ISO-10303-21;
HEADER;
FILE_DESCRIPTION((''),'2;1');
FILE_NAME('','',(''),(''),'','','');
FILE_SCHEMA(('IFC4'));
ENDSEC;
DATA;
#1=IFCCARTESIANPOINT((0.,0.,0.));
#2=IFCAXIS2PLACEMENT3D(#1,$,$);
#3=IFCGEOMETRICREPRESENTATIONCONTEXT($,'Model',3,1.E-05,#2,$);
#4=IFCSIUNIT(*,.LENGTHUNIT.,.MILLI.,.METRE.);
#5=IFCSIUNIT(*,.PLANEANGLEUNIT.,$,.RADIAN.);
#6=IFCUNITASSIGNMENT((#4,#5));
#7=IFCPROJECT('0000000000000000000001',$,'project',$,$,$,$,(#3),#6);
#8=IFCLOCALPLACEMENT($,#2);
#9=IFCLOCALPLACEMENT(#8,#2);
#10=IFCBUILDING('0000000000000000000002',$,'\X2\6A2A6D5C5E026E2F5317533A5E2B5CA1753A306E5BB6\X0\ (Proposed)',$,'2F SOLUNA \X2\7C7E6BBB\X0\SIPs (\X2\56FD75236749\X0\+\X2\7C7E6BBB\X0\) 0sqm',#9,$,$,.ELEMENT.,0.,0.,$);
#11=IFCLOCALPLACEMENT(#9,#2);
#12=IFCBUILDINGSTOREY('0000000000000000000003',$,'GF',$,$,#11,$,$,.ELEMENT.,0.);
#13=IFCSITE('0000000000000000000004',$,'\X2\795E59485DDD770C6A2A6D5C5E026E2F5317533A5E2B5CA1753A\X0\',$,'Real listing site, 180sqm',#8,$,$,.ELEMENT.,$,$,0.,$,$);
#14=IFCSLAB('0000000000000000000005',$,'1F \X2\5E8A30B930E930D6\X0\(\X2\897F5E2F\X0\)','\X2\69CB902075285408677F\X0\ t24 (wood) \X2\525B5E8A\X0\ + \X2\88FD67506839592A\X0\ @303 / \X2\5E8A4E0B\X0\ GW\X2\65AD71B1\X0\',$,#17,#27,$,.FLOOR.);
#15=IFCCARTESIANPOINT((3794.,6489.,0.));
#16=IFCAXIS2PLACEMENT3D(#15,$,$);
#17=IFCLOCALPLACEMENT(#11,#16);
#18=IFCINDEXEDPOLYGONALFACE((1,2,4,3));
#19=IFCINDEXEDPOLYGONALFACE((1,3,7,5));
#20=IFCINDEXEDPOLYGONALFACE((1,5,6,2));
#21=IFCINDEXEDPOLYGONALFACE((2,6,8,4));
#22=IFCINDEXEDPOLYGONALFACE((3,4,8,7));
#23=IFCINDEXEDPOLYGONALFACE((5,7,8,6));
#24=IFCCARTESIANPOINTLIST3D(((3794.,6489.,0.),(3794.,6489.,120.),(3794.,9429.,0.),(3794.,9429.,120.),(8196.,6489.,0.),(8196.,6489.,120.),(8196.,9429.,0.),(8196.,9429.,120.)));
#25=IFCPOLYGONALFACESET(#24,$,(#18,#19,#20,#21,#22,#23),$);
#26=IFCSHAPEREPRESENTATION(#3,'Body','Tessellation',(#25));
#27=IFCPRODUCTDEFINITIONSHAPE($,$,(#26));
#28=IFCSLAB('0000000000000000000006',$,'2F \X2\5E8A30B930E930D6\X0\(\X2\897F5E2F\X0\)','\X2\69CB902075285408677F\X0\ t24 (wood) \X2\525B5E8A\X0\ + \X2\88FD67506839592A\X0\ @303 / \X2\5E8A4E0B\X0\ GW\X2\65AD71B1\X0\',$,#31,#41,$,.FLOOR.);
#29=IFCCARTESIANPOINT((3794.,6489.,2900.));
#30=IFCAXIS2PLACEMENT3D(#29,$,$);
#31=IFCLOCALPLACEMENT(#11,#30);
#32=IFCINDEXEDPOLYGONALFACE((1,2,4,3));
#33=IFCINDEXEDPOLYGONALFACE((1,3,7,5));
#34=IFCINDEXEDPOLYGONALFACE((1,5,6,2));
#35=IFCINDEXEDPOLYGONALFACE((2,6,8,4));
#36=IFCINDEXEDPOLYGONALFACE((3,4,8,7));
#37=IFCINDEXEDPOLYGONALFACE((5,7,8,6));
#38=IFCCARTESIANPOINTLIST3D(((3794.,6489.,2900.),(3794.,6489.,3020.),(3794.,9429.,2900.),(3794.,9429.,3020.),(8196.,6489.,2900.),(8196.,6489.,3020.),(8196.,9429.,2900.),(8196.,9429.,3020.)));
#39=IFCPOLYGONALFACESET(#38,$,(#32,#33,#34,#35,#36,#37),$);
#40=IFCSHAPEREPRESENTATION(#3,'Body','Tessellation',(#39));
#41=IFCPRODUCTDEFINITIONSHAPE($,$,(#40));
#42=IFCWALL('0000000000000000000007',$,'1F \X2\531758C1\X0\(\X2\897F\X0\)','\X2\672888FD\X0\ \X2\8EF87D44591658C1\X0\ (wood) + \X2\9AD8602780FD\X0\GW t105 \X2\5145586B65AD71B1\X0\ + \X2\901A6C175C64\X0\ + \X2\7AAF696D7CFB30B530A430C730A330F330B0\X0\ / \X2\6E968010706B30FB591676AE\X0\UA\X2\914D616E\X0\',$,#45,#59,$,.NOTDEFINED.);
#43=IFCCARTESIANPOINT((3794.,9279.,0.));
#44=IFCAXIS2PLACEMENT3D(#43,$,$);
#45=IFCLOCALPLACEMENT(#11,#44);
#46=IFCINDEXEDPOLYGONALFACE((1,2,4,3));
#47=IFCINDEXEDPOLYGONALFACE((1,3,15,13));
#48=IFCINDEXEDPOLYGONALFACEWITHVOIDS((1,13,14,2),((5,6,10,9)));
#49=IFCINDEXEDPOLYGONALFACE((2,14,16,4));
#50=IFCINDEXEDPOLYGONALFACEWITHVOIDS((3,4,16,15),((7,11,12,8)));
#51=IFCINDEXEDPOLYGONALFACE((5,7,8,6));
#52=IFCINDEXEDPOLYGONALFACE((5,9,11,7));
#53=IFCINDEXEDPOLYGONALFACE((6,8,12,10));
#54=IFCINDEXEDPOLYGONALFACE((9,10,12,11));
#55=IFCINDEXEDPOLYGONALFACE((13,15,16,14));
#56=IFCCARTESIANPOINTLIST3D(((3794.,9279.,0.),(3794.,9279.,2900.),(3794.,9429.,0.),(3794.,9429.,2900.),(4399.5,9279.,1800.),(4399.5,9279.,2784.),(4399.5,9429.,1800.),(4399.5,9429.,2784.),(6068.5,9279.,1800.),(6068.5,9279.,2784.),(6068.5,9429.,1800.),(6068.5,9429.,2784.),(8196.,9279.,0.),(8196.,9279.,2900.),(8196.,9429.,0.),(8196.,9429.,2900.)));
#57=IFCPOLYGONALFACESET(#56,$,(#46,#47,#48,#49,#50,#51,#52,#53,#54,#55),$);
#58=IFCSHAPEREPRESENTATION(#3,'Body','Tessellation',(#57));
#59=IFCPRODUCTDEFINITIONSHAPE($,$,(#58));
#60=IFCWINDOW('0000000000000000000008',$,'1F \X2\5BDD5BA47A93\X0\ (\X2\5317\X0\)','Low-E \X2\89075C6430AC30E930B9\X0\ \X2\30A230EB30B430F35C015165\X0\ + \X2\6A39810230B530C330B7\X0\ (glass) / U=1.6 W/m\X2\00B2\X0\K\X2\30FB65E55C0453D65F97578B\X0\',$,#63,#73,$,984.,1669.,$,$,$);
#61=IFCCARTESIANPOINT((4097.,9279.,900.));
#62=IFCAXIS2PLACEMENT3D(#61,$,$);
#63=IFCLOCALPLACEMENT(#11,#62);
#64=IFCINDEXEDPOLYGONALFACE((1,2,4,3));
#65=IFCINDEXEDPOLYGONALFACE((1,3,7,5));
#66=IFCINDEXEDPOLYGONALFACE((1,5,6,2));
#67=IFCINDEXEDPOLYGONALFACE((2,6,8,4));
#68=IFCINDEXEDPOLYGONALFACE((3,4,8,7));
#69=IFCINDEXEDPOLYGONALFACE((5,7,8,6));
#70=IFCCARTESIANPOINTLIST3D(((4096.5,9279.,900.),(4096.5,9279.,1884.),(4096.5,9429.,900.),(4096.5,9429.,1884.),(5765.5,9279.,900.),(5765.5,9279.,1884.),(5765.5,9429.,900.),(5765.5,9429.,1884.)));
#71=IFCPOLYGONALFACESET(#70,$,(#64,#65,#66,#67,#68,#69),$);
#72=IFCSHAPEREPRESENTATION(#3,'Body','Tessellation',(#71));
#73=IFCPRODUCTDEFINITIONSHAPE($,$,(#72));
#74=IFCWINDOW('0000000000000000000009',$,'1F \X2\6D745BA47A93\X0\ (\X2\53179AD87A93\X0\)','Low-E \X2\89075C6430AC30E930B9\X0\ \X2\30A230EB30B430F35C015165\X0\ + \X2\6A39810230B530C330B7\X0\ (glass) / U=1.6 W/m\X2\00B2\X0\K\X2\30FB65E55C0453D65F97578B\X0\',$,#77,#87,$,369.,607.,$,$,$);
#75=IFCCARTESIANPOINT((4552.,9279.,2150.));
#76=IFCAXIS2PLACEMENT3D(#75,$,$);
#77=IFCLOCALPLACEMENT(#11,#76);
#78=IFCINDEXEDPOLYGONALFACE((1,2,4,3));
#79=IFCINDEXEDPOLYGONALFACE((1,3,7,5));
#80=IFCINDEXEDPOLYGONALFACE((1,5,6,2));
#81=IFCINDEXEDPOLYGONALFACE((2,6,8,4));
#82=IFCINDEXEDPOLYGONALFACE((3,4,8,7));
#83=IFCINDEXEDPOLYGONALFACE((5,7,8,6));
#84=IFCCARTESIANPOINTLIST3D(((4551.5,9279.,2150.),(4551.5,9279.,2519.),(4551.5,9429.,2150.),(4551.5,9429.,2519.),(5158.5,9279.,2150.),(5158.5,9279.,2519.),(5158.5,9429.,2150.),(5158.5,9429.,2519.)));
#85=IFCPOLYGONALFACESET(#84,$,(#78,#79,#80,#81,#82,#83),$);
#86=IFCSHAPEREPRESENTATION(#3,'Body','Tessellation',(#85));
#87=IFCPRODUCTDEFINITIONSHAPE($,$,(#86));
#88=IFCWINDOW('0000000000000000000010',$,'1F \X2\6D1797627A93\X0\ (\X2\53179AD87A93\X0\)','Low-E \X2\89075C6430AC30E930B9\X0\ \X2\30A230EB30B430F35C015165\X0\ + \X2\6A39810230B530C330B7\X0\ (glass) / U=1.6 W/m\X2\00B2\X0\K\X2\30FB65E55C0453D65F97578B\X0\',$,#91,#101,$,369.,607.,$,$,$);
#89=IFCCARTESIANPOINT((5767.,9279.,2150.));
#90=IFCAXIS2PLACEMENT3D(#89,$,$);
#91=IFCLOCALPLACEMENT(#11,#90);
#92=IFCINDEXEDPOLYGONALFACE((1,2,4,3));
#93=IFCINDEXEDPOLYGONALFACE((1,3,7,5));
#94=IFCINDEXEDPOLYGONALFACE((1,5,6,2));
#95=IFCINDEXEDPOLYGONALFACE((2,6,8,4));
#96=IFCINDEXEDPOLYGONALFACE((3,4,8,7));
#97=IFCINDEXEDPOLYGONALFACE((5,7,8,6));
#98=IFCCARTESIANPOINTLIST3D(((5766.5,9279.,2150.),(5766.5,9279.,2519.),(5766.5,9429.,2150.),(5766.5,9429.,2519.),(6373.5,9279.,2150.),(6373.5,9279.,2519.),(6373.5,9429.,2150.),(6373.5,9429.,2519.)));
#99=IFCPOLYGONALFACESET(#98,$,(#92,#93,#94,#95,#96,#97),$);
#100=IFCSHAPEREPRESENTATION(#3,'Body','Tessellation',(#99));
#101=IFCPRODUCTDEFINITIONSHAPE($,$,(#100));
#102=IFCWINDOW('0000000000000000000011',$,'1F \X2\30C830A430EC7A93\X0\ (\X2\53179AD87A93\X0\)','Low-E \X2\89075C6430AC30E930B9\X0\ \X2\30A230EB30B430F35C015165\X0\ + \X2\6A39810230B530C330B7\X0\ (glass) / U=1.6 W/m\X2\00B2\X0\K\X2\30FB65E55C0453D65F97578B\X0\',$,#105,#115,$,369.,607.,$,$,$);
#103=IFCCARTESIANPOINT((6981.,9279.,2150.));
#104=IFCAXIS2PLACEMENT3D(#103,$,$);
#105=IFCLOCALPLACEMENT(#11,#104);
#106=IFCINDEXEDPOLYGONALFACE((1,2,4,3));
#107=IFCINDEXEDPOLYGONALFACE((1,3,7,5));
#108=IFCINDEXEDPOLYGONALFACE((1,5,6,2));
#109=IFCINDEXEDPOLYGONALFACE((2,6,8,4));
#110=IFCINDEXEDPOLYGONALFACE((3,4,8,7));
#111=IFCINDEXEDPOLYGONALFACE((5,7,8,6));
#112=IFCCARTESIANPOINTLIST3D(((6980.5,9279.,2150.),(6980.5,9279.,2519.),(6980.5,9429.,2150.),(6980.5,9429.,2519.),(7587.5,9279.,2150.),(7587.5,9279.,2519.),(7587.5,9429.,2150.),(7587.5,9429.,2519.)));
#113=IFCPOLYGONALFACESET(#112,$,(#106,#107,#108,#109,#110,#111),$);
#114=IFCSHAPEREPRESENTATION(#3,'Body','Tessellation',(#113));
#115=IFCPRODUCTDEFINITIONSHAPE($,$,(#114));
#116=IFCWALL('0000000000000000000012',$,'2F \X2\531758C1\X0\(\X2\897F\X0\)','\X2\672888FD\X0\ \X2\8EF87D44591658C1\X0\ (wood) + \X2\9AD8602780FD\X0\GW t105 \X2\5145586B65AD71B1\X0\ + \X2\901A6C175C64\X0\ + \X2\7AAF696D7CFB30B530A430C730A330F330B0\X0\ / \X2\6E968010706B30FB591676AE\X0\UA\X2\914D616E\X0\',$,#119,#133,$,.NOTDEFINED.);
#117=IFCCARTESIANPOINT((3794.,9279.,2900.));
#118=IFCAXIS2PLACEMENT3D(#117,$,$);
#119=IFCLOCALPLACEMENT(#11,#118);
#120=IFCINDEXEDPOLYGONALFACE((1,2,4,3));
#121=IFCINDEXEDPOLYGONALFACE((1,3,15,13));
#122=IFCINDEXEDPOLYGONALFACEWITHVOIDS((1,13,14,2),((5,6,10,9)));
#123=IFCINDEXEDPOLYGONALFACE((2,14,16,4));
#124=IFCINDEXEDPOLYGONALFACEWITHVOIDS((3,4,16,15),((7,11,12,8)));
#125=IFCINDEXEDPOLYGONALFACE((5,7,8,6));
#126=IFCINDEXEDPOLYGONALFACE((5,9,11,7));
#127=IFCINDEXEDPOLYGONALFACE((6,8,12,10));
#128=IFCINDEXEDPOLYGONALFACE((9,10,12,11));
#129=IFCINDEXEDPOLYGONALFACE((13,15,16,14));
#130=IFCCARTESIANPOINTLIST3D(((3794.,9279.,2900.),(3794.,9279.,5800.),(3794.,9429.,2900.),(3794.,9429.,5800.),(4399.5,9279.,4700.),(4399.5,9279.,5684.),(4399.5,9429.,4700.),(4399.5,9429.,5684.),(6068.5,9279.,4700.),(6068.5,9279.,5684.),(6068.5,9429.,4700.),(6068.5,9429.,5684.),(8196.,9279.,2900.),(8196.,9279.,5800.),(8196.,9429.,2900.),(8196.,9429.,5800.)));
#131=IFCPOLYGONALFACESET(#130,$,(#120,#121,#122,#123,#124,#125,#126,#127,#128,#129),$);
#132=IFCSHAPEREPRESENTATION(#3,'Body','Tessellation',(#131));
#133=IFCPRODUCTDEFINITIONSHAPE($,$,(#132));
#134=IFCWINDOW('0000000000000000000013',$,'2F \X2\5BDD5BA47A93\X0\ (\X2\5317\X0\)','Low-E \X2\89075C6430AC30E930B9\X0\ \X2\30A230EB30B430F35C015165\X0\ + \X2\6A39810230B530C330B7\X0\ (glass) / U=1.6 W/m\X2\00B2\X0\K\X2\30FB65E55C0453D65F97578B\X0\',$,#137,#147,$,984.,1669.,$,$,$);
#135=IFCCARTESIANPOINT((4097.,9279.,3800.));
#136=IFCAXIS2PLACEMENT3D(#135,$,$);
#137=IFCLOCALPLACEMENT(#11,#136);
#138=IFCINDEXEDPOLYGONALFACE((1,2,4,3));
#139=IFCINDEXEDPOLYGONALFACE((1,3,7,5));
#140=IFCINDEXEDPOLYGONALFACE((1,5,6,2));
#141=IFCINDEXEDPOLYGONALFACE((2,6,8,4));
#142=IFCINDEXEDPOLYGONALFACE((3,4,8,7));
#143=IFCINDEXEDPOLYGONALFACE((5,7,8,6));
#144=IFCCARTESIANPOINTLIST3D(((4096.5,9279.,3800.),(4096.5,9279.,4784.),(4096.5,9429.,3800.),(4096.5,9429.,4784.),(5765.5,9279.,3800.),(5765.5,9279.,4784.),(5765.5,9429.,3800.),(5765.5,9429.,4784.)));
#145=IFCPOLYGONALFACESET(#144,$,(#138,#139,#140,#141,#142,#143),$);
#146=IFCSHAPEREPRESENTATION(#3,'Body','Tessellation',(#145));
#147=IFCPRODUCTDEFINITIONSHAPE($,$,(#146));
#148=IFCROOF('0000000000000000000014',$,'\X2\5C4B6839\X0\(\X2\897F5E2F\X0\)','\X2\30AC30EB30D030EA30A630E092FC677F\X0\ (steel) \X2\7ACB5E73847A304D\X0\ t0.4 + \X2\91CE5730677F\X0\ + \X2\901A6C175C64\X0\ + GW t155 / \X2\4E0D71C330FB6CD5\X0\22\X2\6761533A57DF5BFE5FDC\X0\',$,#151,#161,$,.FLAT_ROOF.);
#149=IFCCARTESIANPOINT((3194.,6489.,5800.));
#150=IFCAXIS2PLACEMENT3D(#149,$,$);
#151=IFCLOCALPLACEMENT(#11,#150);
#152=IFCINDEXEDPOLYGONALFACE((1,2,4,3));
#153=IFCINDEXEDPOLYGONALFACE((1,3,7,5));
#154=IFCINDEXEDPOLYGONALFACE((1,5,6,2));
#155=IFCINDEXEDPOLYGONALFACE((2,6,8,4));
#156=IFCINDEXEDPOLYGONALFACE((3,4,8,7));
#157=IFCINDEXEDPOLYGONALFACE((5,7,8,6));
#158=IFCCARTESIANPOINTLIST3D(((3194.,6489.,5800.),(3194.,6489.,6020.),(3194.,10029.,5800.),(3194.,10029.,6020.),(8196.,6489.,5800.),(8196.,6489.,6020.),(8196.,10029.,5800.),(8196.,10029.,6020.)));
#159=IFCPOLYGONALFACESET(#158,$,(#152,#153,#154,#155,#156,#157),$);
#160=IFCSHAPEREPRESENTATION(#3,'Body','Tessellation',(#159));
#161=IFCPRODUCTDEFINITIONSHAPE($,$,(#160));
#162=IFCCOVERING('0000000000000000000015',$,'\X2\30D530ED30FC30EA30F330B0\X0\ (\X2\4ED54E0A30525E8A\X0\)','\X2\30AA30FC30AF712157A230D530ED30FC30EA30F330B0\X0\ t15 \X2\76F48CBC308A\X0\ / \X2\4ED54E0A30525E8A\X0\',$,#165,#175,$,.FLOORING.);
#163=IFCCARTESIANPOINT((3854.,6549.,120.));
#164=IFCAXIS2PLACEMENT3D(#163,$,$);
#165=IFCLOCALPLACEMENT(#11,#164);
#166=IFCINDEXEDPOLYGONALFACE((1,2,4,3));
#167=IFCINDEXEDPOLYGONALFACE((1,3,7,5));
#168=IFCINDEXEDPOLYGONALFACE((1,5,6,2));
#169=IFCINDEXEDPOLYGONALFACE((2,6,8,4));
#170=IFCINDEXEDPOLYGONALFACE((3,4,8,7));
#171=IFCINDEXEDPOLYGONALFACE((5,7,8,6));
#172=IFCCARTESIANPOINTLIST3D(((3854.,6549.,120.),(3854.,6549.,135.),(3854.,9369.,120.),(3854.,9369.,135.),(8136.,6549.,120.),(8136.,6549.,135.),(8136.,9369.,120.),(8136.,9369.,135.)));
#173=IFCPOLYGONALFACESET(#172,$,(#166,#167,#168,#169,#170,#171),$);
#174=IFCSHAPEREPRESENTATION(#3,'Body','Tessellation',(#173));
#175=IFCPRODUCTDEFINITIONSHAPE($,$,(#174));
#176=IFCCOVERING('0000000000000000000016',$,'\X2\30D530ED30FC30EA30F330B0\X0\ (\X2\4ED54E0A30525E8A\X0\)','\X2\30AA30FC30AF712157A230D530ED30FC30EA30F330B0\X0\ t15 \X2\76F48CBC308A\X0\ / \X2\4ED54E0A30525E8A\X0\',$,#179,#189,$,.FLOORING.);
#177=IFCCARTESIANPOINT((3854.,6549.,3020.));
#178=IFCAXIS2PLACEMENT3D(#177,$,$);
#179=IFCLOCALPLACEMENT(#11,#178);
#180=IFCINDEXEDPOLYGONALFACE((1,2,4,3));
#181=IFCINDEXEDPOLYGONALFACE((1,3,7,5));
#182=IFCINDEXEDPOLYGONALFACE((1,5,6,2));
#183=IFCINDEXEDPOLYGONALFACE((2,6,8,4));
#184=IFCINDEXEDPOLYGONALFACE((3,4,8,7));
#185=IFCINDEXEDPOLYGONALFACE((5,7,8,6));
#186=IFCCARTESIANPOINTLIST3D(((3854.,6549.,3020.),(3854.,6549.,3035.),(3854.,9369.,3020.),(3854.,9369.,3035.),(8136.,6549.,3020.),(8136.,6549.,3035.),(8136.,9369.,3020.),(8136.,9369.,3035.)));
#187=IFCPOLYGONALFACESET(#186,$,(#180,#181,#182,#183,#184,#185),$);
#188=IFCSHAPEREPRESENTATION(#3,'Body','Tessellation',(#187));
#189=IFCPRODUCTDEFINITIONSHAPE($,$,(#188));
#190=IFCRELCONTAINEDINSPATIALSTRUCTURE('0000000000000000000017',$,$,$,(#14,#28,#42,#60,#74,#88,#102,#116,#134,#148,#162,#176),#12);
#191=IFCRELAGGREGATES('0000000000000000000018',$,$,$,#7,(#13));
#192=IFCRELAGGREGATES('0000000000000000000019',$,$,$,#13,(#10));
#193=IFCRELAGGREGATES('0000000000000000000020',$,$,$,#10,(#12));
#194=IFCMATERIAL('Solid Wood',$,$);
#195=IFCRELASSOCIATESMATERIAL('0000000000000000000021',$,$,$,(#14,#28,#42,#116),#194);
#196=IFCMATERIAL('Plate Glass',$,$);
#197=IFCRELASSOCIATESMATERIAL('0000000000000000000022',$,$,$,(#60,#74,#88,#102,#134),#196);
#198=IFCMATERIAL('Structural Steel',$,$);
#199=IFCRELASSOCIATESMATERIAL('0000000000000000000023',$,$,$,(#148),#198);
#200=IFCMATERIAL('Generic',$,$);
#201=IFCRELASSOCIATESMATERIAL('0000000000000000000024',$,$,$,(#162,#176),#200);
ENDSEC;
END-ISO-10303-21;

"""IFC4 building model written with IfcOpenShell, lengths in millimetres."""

from ifc_helpers import new_model, si_unit, frame, frame_2d, origin, place, context, project, spatial, rectangle, extrude, material, element, fill, save


model = new_model("IFC4")

# Units and contexts
model_context = context("Model", 3, precision=1e-05, world=origin())
ifc_project = project(units=[si_unit("LENGTHUNIT", "METRE", prefix="MILLI"), si_unit("PLANEANGLEUNIT", "RADIAN")], contexts=[model_context])

# Site, building, storey
site_placement = place(None, origin())
site = spatial("IfcSite", under=ifc_project, at=site_placement, Name="神奈川県横浜市港北区師岡町", ObjectType="Real listing site, 180sqm", CompositionType="ELEMENT", RefElevation=0.0)
building_placement = place(site_placement, origin())
building = spatial("IfcBuilding", under=site, at=building_placement, Name="横浜市港北区師岡町の家 (Proposed)", ObjectType="2F SOLUNA 籾殻SIPs (国産杉+籾殻) 0sqm", CompositionType="ELEMENT", ElevationOfRefHeight=0.0, ElevationOfTerrain=0.0)
storey_placement = place(building_placement, origin())
storey = spatial("IfcBuildingStorey", under=building, at=storey_placement, Name="GF", CompositionType="ELEMENT", Elevation=0.0)

# Slabs
ifc_material_1 = material(Name="Solid Wood")
slab_1_placement = place(storey_placement, frame((3794.0, 6489.0, 0.0)))
element("IfcSlab", 1, at=slab_1_placement, inside=storey, material=ifc_material_1, Name="1F 床スラブ(西帯)", Description="構造用合板 t24 (wood) 剛床 + 製材根太 @303 / 床下 GW断熱", PredefinedType="FLOOR", context=model_context, shape_type="SweptSolid", body=[
    extrude(rectangle(XDim=4402.0, YDim=2940.0, at=frame_2d((2201.0, 1470.0))), frame((3794.0, 6489.0, 0.0)), (0.0, 0.0, 1.0), 120.0),
])
slab_2_placement = place(storey_placement, frame((3794.0, 6489.0, 2900.0)))
element("IfcSlab", 2, at=slab_2_placement, inside=storey, material=ifc_material_1, Name="2F 床スラブ(西帯)", Description="構造用合板 t24 (wood) 剛床 + 製材根太 @303 / 床下 GW断熱", PredefinedType="FLOOR", context=model_context, shape_type="SweptSolid", body=[
    extrude(rectangle(XDim=4402.0, YDim=2940.0, at=frame_2d((2201.0, 1470.0))), frame((3794.0, 6489.0, 2900.0)), (0.0, 0.0, 1.0), 120.0),
])

# Wall, openings, windows
wall_1_placement = place(storey_placement, frame((3794.0, 9279.0, 0.0)))
wall_1 = element("IfcWall", 3, at=wall_1_placement, inside=storey, material=ifc_material_1, Name="1F 北壁(西)", Description="木製 軸組外壁 (wood) + 高性能GW t105 充填断熱 + 通気層 + 窯業系サイディング / 準耐火・外皮UA配慮", PredefinedType="NOTDEFINED", context=model_context, shape_type="SweptSolid", body=[
    extrude(rectangle(XDim=4402.0, YDim=150.0, at=frame_2d((2201.0, 75.0))), frame((3794.0, 9279.0, 0.0)), (0.0, 0.0, 1.0), 2900.0),
])
opening_1_placement = place(storey_placement, frame((4097.0, 9279.0, 900.0)))
opening_1 = element("IfcOpeningElement", 4, at=opening_1_placement, cuts=wall_1, PredefinedType="NOTDEFINED", context=model_context, shape_type="SweptSolid", body=[
    extrude(rectangle(XDim=1669.0, YDim=150.0, at=frame_2d((834.0, 75.0))), frame((4097.0, 9279.0, 900.0)), (0.0, 0.0, 1.0), 984.0),
])
opening_2_placement = place(storey_placement, frame((4552.0, 9279.0, 2150.0)))
opening_2 = element("IfcOpeningElement", 5, at=opening_2_placement, cuts=wall_1, PredefinedType="NOTDEFINED", context=model_context, shape_type="SweptSolid", body=[
    extrude(rectangle(XDim=607.0, YDim=150.0, at=frame_2d((303.0, 75.0))), frame((4552.0, 9279.0, 2150.0)), (0.0, 0.0, 1.0), 369.0),
])
opening_3_placement = place(storey_placement, frame((5767.0, 9279.0, 2150.0)))
opening_3 = element("IfcOpeningElement", 6, at=opening_3_placement, cuts=wall_1, PredefinedType="NOTDEFINED", context=model_context, shape_type="SweptSolid", body=[
    extrude(rectangle(XDim=607.0, YDim=150.0, at=frame_2d((303.0, 75.0))), frame((5767.0, 9279.0, 2150.0)), (0.0, 0.0, 1.0), 369.0),
])
opening_4_placement = place(storey_placement, frame((6981.0, 9279.0, 2150.0)))
opening_4 = element("IfcOpeningElement", 7, at=opening_4_placement, cuts=wall_1, PredefinedType="NOTDEFINED", context=model_context, shape_type="SweptSolid", body=[
    extrude(rectangle(XDim=607.0, YDim=150.0, at=frame_2d((303.0, 75.0))), frame((6981.0, 9279.0, 2150.0)), (0.0, 0.0, 1.0), 369.0),
])
ifc_material_2 = material(Name="Plate Glass")
window_1_placement = place(storey_placement, frame((4097.0, 9279.0, 900.0)))
window_1 = element("IfcWindow", 8, at=window_1_placement, inside=storey, material=ifc_material_2, Name="1F 寝室窓 (北)", Description="Low-E 複層ガラス アルゴン封入 + 樹脂サッシ (glass) / U=1.6 W/m²K・日射取得型", OverallHeight=984.0, OverallWidth=1669.0, context=model_context, shape_type="SweptSolid", body=[
    extrude(rectangle(XDim=1669.0, YDim=150.0, at=frame_2d((834.0, 75.0))), frame((4097.0, 9279.0, 900.0)), (0.0, 0.0, 1.0), 984.0),
])
fill(opening_1, window_1)
window_2_placement = place(storey_placement, frame((4552.0, 9279.0, 2150.0)))
window_2 = element("IfcWindow", 9, at=window_2_placement, inside=storey, material=ifc_material_2, Name="1F 浴室窓 (北高窓)", Description="Low-E 複層ガラス アルゴン封入 + 樹脂サッシ (glass) / U=1.6 W/m²K・日射取得型", OverallHeight=369.0, OverallWidth=607.0, context=model_context, shape_type="SweptSolid", body=[
    extrude(rectangle(XDim=607.0, YDim=150.0, at=frame_2d((303.0, 75.0))), frame((4552.0, 9279.0, 2150.0)), (0.0, 0.0, 1.0), 369.0),
])
fill(opening_2, window_2)
window_3_placement = place(storey_placement, frame((5767.0, 9279.0, 2150.0)))
window_3 = element("IfcWindow", 10, at=window_3_placement, inside=storey, material=ifc_material_2, Name="1F 洗面窓 (北高窓)", Description="Low-E 複層ガラス アルゴン封入 + 樹脂サッシ (glass) / U=1.6 W/m²K・日射取得型", OverallHeight=369.0, OverallWidth=607.0, context=model_context, shape_type="SweptSolid", body=[
    extrude(rectangle(XDim=607.0, YDim=150.0, at=frame_2d((303.0, 75.0))), frame((5767.0, 9279.0, 2150.0)), (0.0, 0.0, 1.0), 369.0),
])
fill(opening_3, window_3)
window_4_placement = place(storey_placement, frame((6981.0, 9279.0, 2150.0)))
window_4 = element("IfcWindow", 11, at=window_4_placement, inside=storey, material=ifc_material_2, Name="1F トイレ窓 (北高窓)", Description="Low-E 複層ガラス アルゴン封入 + 樹脂サッシ (glass) / U=1.6 W/m²K・日射取得型", OverallHeight=369.0, OverallWidth=607.0, context=model_context, shape_type="SweptSolid", body=[
    extrude(rectangle(XDim=607.0, YDim=150.0, at=frame_2d((303.0, 75.0))), frame((6981.0, 9279.0, 2150.0)), (0.0, 0.0, 1.0), 369.0),
])
fill(opening_4, window_4)

# Wall, opening, window
wall_2_placement = place(storey_placement, frame((3794.0, 9279.0, 2900.0)))
wall_2 = element("IfcWall", 12, at=wall_2_placement, inside=storey, material=ifc_material_1, Name="2F 北壁(西)", Description="木製 軸組外壁 (wood) + 高性能GW t105 充填断熱 + 通気層 + 窯業系サイディング / 準耐火・外皮UA配慮", PredefinedType="NOTDEFINED", context=model_context, shape_type="SweptSolid", body=[
    extrude(rectangle(XDim=4402.0, YDim=150.0, at=frame_2d((2201.0, 75.0))), frame((3794.0, 9279.0, 2900.0)), (0.0, 0.0, 1.0), 2900.0),
])
opening_5_placement = place(storey_placement, frame((4097.0, 9279.0, 3800.0)))
opening_5 = element("IfcOpeningElement", 13, at=opening_5_placement, cuts=wall_2, PredefinedType="NOTDEFINED", context=model_context, shape_type="SweptSolid", body=[
    extrude(rectangle(XDim=1669.0, YDim=150.0, at=frame_2d((834.0, 75.0))), frame((4097.0, 9279.0, 3800.0)), (0.0, 0.0, 1.0), 984.0),
])
window_5_placement = place(storey_placement, frame((4097.0, 9279.0, 3800.0)))
window_5 = element("IfcWindow", 14, at=window_5_placement, inside=storey, material=ifc_material_2, Name="2F 寝室窓 (北)", Description="Low-E 複層ガラス アルゴン封入 + 樹脂サッシ (glass) / U=1.6 W/m²K・日射取得型", OverallHeight=984.0, OverallWidth=1669.0, context=model_context, shape_type="SweptSolid", body=[
    extrude(rectangle(XDim=1669.0, YDim=150.0, at=frame_2d((834.0, 75.0))), frame((4097.0, 9279.0, 3800.0)), (0.0, 0.0, 1.0), 984.0),
])
fill(opening_5, window_5)

# Roof
ifc_material_3 = material(Name="Structural Steel")
for number, where, name in (
    (15, (3194.0, 6489.0, 5800.0), "屋根(西帯)"),
):
    element("IfcRoof", number, at=place(storey_placement, frame(where)), inside=storey, material=ifc_material_3, Name=name, Description="ガルバリウム鋼板 (steel) 立平葺き t0.4 + 野地板 + 通気層 + GW t155 / 不燃・法22条区域対応", PredefinedType="FLAT_ROOF", context=model_context, shape_type="SweptSolid", body=[
        extrude(rectangle(XDim=5002.0, YDim=3540.0, at=frame_2d((2501.0, 1770.0))), frame((3194.0, 6489.0, 5800.0)), (0.0, 0.0, 1.0), 220.0),
    ])

# Coverings
ifc_material_4 = material(Name="Generic")
covering_1_placement = place(storey_placement, frame((3854.0, 6549.0, 120.0)))
element("IfcCovering", 16, at=covering_1_placement, inside=storey, material=ifc_material_4, Name="フローリング (仕上げ床)", Description="オーク無垢フローリング t15 直貼り / 仕上げ床", PredefinedType="FLOORING", context=model_context, shape_type="SweptSolid", body=[
    extrude(rectangle(XDim=4282.0, YDim=2820.0, at=frame_2d((2141.0, 1410.0))), frame((3854.0, 6549.0, 120.0)), (0.0, 0.0, 1.0), 15.0),
])
covering_2_placement = place(storey_placement, frame((3854.0, 6549.0, 3020.0)))
element("IfcCovering", 17, at=covering_2_placement, inside=storey, material=ifc_material_4, Name="フローリング (仕上げ床)", Description="オーク無垢フローリング t15 直貼り / 仕上げ床", PredefinedType="FLOORING", context=model_context, shape_type="SweptSolid", body=[
    extrude(rectangle(XDim=4282.0, YDim=2820.0, at=frame_2d((2141.0, 1410.0))), frame((3854.0, 6549.0, 3020.0)), (0.0, 0.0, 1.0), 15.0),
])

save(model, "model.ifc")
